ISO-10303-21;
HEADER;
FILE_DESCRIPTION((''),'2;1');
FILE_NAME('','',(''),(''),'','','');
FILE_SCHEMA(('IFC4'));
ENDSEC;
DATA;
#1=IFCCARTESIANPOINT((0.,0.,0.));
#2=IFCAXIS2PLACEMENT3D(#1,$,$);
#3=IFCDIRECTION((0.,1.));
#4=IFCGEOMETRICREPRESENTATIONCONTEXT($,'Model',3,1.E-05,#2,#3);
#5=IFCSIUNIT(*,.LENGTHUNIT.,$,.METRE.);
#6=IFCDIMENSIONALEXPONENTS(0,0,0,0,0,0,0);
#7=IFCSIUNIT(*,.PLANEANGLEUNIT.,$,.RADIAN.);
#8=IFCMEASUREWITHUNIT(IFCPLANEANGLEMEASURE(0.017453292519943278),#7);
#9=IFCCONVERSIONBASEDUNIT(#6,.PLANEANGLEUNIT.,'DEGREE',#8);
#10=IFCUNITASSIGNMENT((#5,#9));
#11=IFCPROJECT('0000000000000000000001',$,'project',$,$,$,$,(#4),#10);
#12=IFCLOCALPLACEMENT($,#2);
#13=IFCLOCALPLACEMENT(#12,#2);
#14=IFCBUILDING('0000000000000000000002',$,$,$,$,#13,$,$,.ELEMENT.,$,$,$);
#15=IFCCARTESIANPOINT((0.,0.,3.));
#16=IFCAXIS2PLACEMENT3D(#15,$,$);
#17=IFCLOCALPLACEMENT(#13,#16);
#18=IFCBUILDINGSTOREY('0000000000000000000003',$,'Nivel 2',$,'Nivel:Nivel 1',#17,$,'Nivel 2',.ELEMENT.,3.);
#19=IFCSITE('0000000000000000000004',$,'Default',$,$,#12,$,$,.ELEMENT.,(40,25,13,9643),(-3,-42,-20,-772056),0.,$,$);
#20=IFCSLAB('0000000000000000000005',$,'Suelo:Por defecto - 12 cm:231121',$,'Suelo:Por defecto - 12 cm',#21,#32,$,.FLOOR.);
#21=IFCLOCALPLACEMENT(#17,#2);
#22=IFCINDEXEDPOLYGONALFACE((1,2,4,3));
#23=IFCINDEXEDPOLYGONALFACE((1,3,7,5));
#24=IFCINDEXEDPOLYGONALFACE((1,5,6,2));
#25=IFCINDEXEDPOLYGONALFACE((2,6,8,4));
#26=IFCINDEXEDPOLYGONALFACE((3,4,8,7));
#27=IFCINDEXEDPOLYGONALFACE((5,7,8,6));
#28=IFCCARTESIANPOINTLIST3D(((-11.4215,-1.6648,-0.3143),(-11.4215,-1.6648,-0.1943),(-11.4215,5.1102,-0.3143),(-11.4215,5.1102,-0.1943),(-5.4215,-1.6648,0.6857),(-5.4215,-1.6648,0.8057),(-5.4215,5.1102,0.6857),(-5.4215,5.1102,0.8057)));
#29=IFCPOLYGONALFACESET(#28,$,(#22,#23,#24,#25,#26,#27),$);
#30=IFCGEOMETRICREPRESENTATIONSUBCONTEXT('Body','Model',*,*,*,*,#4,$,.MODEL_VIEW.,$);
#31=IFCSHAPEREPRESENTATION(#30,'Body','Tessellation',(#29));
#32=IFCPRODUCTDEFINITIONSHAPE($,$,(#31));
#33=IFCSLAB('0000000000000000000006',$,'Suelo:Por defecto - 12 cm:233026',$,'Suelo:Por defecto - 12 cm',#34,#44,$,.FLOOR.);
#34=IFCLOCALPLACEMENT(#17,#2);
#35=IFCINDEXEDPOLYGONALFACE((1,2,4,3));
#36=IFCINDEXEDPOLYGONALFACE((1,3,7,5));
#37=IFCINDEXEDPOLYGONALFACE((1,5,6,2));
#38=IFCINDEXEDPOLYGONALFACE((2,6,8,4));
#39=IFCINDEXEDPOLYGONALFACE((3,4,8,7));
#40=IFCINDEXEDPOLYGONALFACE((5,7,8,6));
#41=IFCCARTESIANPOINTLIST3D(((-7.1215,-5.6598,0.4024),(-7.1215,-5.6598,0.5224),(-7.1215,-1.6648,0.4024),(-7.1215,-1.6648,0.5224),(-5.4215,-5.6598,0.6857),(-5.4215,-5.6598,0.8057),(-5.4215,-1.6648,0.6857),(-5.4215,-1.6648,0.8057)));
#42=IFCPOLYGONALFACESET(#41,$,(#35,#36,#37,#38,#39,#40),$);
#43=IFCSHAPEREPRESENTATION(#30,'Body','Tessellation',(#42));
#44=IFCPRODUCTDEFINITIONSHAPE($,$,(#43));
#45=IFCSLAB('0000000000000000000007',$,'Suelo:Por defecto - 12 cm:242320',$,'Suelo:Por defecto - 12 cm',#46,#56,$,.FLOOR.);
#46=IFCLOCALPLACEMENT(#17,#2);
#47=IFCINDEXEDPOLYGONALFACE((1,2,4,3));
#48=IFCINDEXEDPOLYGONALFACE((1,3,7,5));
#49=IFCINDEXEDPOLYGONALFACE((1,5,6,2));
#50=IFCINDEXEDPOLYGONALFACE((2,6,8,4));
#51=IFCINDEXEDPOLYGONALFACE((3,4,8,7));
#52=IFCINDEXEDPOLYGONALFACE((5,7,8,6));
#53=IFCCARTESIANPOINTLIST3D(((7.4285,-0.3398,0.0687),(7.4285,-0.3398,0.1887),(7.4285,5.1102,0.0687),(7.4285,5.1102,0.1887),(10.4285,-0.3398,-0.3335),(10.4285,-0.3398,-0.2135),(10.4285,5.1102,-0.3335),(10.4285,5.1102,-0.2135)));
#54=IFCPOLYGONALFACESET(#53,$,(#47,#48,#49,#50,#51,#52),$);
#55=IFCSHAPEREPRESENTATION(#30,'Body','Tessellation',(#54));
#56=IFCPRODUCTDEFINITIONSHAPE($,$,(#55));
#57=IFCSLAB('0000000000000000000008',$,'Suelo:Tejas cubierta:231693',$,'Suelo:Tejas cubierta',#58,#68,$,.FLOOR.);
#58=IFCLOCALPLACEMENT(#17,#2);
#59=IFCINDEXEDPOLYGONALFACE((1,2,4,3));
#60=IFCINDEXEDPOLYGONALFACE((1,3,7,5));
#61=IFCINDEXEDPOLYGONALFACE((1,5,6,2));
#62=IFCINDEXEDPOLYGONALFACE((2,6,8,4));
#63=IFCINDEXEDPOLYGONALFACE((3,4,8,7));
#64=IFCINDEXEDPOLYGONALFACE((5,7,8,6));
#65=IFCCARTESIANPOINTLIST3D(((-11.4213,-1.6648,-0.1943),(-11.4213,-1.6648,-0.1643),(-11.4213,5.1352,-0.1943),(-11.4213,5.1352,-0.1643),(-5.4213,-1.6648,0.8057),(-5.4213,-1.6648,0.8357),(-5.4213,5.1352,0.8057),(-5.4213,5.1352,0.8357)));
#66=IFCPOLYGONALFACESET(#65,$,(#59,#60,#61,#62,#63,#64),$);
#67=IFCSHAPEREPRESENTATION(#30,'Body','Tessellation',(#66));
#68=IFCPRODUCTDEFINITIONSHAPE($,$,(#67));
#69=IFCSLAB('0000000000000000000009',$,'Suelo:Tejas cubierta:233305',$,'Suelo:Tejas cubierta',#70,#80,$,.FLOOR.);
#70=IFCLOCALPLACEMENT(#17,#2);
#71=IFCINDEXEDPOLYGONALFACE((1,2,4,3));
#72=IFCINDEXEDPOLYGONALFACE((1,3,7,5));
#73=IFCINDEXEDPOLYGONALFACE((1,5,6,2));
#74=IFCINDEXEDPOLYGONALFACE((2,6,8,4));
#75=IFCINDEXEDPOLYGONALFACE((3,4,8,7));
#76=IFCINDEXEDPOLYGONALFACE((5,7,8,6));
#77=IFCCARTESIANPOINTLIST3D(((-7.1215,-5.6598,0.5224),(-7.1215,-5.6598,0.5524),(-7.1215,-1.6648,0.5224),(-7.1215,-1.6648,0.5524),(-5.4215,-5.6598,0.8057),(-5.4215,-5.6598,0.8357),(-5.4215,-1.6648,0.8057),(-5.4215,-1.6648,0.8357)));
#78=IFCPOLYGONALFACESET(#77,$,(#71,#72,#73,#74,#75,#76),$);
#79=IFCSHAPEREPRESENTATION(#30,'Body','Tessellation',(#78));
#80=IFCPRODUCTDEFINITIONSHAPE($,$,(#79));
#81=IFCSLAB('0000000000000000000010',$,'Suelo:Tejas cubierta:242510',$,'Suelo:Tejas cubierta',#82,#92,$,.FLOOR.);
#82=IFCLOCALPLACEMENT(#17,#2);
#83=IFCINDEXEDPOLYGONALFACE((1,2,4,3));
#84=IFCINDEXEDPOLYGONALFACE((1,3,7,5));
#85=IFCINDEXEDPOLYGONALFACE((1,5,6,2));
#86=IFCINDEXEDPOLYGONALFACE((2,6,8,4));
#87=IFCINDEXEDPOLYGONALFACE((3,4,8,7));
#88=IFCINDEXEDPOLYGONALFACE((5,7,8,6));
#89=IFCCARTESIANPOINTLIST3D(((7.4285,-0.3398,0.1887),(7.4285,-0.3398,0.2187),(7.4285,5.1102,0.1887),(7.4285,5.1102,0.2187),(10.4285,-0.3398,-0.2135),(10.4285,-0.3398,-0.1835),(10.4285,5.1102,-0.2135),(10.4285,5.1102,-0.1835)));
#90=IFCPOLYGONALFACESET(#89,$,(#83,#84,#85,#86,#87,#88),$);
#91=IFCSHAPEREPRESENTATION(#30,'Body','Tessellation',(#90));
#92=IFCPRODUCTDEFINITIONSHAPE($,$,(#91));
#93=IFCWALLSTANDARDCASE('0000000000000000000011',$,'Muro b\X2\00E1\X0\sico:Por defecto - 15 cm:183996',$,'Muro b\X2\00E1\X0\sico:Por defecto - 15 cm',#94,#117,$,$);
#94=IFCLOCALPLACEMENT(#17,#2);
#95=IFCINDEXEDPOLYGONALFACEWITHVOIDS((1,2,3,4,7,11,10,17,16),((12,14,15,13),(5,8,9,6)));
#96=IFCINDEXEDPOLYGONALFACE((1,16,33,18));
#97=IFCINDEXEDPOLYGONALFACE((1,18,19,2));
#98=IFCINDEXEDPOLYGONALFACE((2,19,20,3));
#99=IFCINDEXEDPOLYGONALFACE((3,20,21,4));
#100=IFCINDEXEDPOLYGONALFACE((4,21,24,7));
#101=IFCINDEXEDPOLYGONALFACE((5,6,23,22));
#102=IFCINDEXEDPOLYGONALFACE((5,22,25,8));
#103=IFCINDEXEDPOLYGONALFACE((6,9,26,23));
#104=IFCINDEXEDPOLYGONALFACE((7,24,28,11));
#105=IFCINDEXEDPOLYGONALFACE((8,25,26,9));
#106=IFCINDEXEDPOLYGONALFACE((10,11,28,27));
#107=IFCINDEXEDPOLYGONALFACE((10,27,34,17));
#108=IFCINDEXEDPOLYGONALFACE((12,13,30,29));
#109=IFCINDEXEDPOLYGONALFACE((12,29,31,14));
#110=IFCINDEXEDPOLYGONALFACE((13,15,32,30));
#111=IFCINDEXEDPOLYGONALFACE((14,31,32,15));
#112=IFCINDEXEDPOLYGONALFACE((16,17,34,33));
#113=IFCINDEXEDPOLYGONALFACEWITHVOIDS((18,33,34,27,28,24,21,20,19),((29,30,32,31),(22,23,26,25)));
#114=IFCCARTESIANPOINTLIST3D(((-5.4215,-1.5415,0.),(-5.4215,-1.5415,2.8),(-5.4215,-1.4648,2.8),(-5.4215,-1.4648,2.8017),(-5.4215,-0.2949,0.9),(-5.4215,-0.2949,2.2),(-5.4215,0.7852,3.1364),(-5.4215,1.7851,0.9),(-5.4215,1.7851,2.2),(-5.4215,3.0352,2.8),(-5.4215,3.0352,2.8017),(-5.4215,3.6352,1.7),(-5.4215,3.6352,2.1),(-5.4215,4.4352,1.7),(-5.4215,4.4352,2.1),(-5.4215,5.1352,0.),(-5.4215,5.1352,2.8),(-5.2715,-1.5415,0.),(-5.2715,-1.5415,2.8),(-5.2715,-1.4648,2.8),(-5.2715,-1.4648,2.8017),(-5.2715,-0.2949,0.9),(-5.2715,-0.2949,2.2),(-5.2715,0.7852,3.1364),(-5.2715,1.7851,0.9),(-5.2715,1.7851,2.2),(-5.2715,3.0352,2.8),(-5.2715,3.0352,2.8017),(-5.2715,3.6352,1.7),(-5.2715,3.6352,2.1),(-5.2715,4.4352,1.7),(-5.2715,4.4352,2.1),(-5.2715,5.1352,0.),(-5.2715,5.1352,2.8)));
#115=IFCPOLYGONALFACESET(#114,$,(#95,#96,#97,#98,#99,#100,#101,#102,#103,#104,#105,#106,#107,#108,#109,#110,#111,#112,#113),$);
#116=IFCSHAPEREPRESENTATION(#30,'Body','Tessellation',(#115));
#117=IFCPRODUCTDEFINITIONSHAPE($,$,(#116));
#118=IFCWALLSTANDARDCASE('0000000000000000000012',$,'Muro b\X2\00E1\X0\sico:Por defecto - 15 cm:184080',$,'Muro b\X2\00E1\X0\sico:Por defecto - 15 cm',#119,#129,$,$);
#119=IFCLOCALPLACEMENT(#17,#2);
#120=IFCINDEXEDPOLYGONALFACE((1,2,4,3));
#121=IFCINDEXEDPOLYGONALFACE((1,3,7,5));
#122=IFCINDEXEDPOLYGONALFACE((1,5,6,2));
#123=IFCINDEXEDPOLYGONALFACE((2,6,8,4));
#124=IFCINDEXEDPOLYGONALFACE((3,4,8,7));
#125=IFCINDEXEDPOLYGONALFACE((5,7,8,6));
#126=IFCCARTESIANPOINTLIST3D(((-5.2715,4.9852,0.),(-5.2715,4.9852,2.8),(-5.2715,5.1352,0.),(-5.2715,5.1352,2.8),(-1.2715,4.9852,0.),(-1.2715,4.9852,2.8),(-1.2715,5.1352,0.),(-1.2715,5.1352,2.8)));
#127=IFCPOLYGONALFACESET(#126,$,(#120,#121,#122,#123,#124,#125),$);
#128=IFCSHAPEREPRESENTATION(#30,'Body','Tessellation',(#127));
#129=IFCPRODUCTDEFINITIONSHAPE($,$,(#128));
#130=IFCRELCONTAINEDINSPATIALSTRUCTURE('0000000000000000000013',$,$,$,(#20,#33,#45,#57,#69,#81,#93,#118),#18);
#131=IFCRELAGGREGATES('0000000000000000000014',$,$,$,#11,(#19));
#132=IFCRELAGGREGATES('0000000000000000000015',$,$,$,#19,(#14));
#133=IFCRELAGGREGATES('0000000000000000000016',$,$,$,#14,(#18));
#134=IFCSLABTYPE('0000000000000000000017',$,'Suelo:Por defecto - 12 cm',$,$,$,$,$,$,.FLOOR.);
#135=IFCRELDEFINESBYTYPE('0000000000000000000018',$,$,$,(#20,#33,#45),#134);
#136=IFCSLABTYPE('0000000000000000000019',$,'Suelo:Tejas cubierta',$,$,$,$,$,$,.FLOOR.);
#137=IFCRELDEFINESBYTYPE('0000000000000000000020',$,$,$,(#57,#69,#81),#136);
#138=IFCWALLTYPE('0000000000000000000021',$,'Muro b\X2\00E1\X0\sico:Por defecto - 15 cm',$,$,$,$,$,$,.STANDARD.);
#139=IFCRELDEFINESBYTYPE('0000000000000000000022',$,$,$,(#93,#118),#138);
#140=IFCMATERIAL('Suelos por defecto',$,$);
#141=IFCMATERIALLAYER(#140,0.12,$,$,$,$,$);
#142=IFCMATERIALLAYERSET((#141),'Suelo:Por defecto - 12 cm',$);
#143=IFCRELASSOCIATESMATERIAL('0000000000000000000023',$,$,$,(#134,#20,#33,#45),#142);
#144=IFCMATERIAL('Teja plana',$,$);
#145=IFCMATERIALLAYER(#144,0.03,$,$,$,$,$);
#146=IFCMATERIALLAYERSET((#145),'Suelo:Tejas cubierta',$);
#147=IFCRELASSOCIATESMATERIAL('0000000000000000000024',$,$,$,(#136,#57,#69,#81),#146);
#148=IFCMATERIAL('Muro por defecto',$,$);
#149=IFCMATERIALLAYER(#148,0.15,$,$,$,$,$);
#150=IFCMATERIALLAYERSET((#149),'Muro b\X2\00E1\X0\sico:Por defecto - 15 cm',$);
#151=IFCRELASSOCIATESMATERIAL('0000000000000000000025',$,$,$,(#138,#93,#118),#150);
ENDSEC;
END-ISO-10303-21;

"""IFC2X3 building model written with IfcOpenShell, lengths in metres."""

from ifc_helpers import new_model, entity, si_unit, converted_unit, direction, frame, frame_2d, origin, place, context, subcontext, project, spatial, polyline, rectangle, extrude, clip, halfspace, bounded_halfspace, material, layer, layer_set, layer_usage, type_object, element, save


model = new_model("IFC2X3")

# Units and contexts
model_context = context("Model", 3, precision=1e-05, world=origin(), true_north=direction((0.0, 1.0)))
body_context = subcontext(model_context, "Body", "Model", "MODEL_VIEW")
ifc_project = project(units=[si_unit("LENGTHUNIT", "METRE"), converted_unit("PLANEANGLEUNIT", "DEGREE", entity("IfcPlaneAngleMeasure", 0.017453292519943278), si_unit("PLANEANGLEUNIT", "RADIAN"), dimensions=[0, 0, 0, 0, 0, 0, 0])], contexts=[model_context])

# Site, building, storey
site_placement = place(None, origin())
site = spatial("IfcSite", under=ifc_project, at=site_placement, Name="Default", CompositionType="ELEMENT", RefLatitude=(40, 25, 13, 9643), RefLongitude=(-3, -42, -20, -772056), RefElevation=0.0)
building_placement = place(site_placement, origin())
building = spatial("IfcBuilding", under=site, at=building_placement, CompositionType="ELEMENT")
storey_placement = place(building_placement, frame((0.0, 0.0, 3.0)))
storey = spatial("IfcBuildingStorey", under=building, at=storey_placement, Name="Nivel 2", ObjectType="Nivel:Nivel 1", LongName="Nivel 2", CompositionType="ELEMENT", Elevation=3.0)

# Shared definitions
ifc_material_1 = material(Name="Suelos por defecto")

# Slabs
ifc_layer_1 = layer(ifc_material_1, 0.12)
ifc_layer_set_1 = layer_set([ifc_layer_1], Name="Suelo:Por defecto - 12 cm")
ifc_layer_usage_1 = layer_usage(ifc_layer_set_1, "AXIS3", "POSITIVE", 0.0)
slab_type_1 = type_object("IfcSlabType", Name="Suelo:Por defecto - 12 cm", PredefinedType="FLOOR", material=ifc_layer_set_1)
slab_1_placement = place(storey_placement, origin())
element("IfcSlab", 1, at=slab_1_placement, inside=storey, type_object=slab_type_1, material=ifc_layer_usage_1, Name="Suelo:Por defecto - 12 cm:231121", ObjectType="Suelo:Por defecto - 12 cm", PredefinedType="FLOOR", context=body_context, shape_type="SweptSolid", body=[
    clip(clip(extrude(rectangle(XDim=6.0828, YDim=6.775, at=frame_2d((0.0, 0.0), x_axis=(0.0, 1.0))), frame((-8.4215, 1.7227, 0.3057), z_axis=(0.164399, 0.0, -0.986394), x_axis=(0.0, 1.0, 0.0)), (0.0, -0.164399, 0.986394), 0.1217), halfspace(frame((-8.4215, 1.7227, 0.1857), z_axis=(0.164399, 0.0, -0.986394), x_axis=(0.986394, 0.0, 0.164399)), False)), halfspace(frame((-8.4215, 1.7227, 0.3057), z_axis=(-0.164399, 0.0, 0.986394), x_axis=(0.986394, 0.0, 0.164399)), False)),
])
ifc_layer_usage_2 = layer_usage(ifc_layer_set_1, "AXIS3", "POSITIVE", 0.0)
slab_2_placement = place(storey_placement, origin())
element("IfcSlab", 2, at=slab_2_placement, inside=storey, type_object=slab_type_1, material=ifc_layer_usage_2, Name="Suelo:Por defecto - 12 cm:233026", ObjectType="Suelo:Por defecto - 12 cm", PredefinedType="FLOOR", context=body_context, shape_type="SweptSolid", body=[
    clip(clip(extrude(rectangle(XDim=1.7234, YDim=3.995, at=frame_2d((0.0, 0.0), x_axis=(0.0, 1.0))), frame((-6.2715, -3.6623, 0.664), z_axis=(0.164399, 0.0, -0.986394), x_axis=(0.0, 1.0, 0.0)), (0.0, -0.164399, 0.986394), 0.1217), halfspace(frame((-6.2715, -3.6623, 0.544), z_axis=(0.164399, 0.0, -0.986394), x_axis=(-0.986394, 0.0, -0.164399)), False)), halfspace(frame((-6.2715, -3.6623, 0.664), z_axis=(-0.164399, 0.0, 0.986394), x_axis=(-0.986394, 0.0, -0.164399)), False)),
])
ifc_layer_usage_3 = layer_usage(ifc_layer_set_1, "AXIS3", "POSITIVE", 0.0)
slab_3_placement = place(storey_placement, origin())
element("IfcSlab", 3, at=slab_3_placement, inside=storey, type_object=slab_type_1, material=ifc_layer_usage_3, Name="Suelo:Por defecto - 12 cm:242320", ObjectType="Suelo:Por defecto - 12 cm", PredefinedType="FLOOR", context=body_context, shape_type="SweptSolid", body=[
    clip(clip(extrude(rectangle(XDim=3.0268, YDim=5.45, at=frame_2d((0.0, 0.0), x_axis=(0.0, 1.0))), frame((8.9285, 2.3852, -0.0124), z_axis=(-0.132875, 0.0, -0.991133), x_axis=(0.0, 1.0, 0.0)), (0.0, 0.132875, 0.991133), 0.1211), halfspace(frame((8.9285, 2.3852, -0.1324), z_axis=(-0.132875, 0.0, -0.991133), x_axis=(0.0, 1.0, 0.0)), False)), halfspace(frame((8.9285, 2.3852, -0.0124), z_axis=(0.132875, 0.0, 0.991133), x_axis=(0.0, 1.0, 0.0)), False)),
])
ifc_material_2 = material(Name="Teja plana")
ifc_layer_2 = layer(ifc_material_2, 0.03)
ifc_layer_set_2 = layer_set([ifc_layer_2], Name="Suelo:Tejas cubierta")
ifc_layer_usage_4 = layer_usage(ifc_layer_set_2, "AXIS3", "POSITIVE", 0.0)
slab_type_2 = type_object("IfcSlabType", Name="Suelo:Tejas cubierta", PredefinedType="FLOOR", material=ifc_layer_set_2)
slab_4_placement = place(storey_placement, origin())
element("IfcSlab", 4, at=slab_4_placement, inside=storey, type_object=slab_type_2, material=ifc_layer_usage_4, Name="Suelo:Tejas cubierta:231693", ObjectType="Suelo:Tejas cubierta", PredefinedType="FLOOR", context=body_context, shape_type="SweptSolid", body=[
    clip(clip(extrude(rectangle(XDim=6.0828, YDim=6.8, at=frame_2d((0.0, 0.0), x_axis=(0.0, 1.0))), frame((-8.4213, 1.7352, 0.3357), z_axis=(0.164399, 0.0, -0.986394), x_axis=(0.0, 1.0, 0.0)), (0.0, -0.164399, 0.986394), 0.0304), halfspace(frame((-8.4213, 1.7352, 0.3057), z_axis=(0.164399, 0.0, -0.986394), x_axis=(0.986394, 0.0, 0.164399)), False)), halfspace(frame((-8.4213, 1.7352, 0.3357), z_axis=(-0.164399, 0.0, 0.986394), x_axis=(0.986394, 0.0, 0.164399)), False)),
])
ifc_layer_usage_5 = layer_usage(ifc_layer_set_2, "AXIS3", "POSITIVE", 0.0)
slab_5_placement = place(storey_placement, origin())
element("IfcSlab", 5, at=slab_5_placement, inside=storey, type_object=slab_type_2, material=ifc_layer_usage_5, Name="Suelo:Tejas cubierta:233305", ObjectType="Suelo:Tejas cubierta", PredefinedType="FLOOR", context=body_context, shape_type="SweptSolid", body=[
    clip(clip(extrude(rectangle(XDim=1.7234, YDim=3.995, at=frame_2d((0.0, 0.0), x_axis=(0.0, 1.0))), frame((-6.2715, -3.6623, 0.694), z_axis=(0.164399, 0.0, -0.986394), x_axis=(0.0, 1.0, 0.0)), (0.0, -0.164399, 0.986394), 0.0304), halfspace(frame((-6.2715, -3.6623, 0.664), z_axis=(0.164399, 0.0, -0.986394), x_axis=(-0.986394, 0.0, -0.164399)), False)), halfspace(frame((-6.2715, -3.6623, 0.694), z_axis=(-0.164399, 0.0, 0.986394), x_axis=(-0.986394, 0.0, -0.164399)), False)),
])
ifc_layer_usage_6 = layer_usage(ifc_layer_set_2, "AXIS3", "POSITIVE", 0.0)
slab_6_placement = place(storey_placement, origin())
element("IfcSlab", 6, at=slab_6_placement, inside=storey, type_object=slab_type_2, material=ifc_layer_usage_6, Name="Suelo:Tejas cubierta:242510", ObjectType="Suelo:Tejas cubierta", PredefinedType="FLOOR", context=body_context, shape_type="SweptSolid", body=[
    clip(clip(extrude(rectangle(XDim=3.0268, YDim=5.45, at=frame_2d((0.0, 0.0), x_axis=(0.0, 1.0))), frame((8.9285, 2.3852, 0.0176), z_axis=(-0.132875, 0.0, -0.991133), x_axis=(0.0, 1.0, 0.0)), (0.0, 0.132875, 0.991133), 0.0303), halfspace(frame((8.9285, 2.3852, -0.0124), z_axis=(-0.132875, 0.0, -0.991133), x_axis=(0.0, 1.0, 0.0)), False)), halfspace(frame((8.9285, 2.3852, 0.0176), z_axis=(0.132875, 0.0, 0.991133), x_axis=(0.0, 1.0, 0.0)), False)),
])

# Wall, openings
ifc_material_3 = material(Name="Muro por defecto")
ifc_layer_3 = layer(ifc_material_3, 0.15)
ifc_layer_set_3 = layer_set([ifc_layer_3], Name="Muro básico:Por defecto - 15 cm")
ifc_layer_usage_7 = layer_usage(ifc_layer_set_3, "AXIS2", "NEGATIVE", 0.075)
wall_type = type_object("IfcWallType", Name="Muro básico:Por defecto - 15 cm", PredefinedType="STANDARD", material=ifc_layer_set_3)
wall_1_placement = place(storey_placement, frame((-5.3465, -1.5415, 0.0), z_axis=(0.0, 0.0, 1.0), x_axis=(0.0, 1.0, 0.0)))
wall_1 = element("IfcWallStandardCase", 7, at=wall_1_placement, inside=storey, type_object=wall_type, material=ifc_layer_usage_7, Name="Muro básico:Por defecto - 15 cm:183996", ObjectType="Muro básico:Por defecto - 15 cm", context=body_context, shape_type="Clipping", body=[
    clip(clip(clip(clip(clip(extrude(rectangle(XDim=6.6768, YDim=0.15, at=frame_2d((3.3384, 0.0), x_axis=(-1.0, 0.0))), origin(), (0.0, 0.0, 1.0), 3.1364), bounded_halfspace(frame((4.5768, -0.075, 2.8), z_axis=(0.0, 0.0, -1.0), x_axis=(0.0, -1.0, 0.0)), True, frame((4.5768, -0.075, 2.8)), polyline([(0.0, 0.0), (0.075, 0.0), (1.95, 0.0), (2.1, 0.0), (2.1, 0.15), (0.0, 0.15), (0.0, 0.0)]))), bounded_halfspace(frame((2.3268, -0.075, 3.1364), z_axis=(0.147125, 0.0, 0.989118), x_axis=(0.0, 1.0, 0.0)), False, frame((2.3268, -0.075, 3.1364)), polyline([(0.0, 0.0), (2.25, 0.0), (2.25, 0.15), (0.0, 0.15), (0.0, 0.0)]))), bounded_halfspace(frame((0.0768, -0.075, 2.8017), z_axis=(-0.147131, 0.0, 0.989117), x_axis=(0.0, -1.0, 0.0)), False, frame((0.0768, -0.075, 2.8017)), polyline([(0.0, 0.0), (2.25, 0.0), (2.25, 0.15), (0.0, 0.15), (0.0, 0.0)]))), bounded_halfspace(frame((4.5768, -0.075, 2.8), z_axis=(0.0, 0.0, -1.0), x_axis=(0.0, -1.0, 0.0)), True, frame((4.5768, -0.075, 2.8)), polyline([(0.0, 0.0), (0.075, 0.0), (1.95, 0.0), (2.1, 0.0), (2.1, 0.15), (0.0, 0.15), (0.0, 0.0)]))), bounded_halfspace(frame((0.0, -0.075, 2.8), z_axis=(0.0, 0.0, 1.0), x_axis=(0.0, 1.0, 0.0)), False, frame((0.0, -0.075, 2.8)), polyline([(0.0, 0.0), (0.0768, 0.0), (0.0768, 0.15), (0.0, 0.15), (0.0, 0.0)]))),
])
opening_1_placement = place(wall_1_placement, frame((5.1768, -0.075, 1.7)))
element("IfcOpeningElement", 8, at=opening_1_placement, cuts=wall_1, ObjectType="Opening", context=body_context, shape_type="SweptSolid", body=[
    extrude(rectangle(XDim=0.4, YDim=0.8, at=frame_2d((0.2, 0.4), x_axis=(1.0, 0.0))), frame((0.0, 0.0, 0.0), z_axis=(0.0, 1.0, 0.0), x_axis=(0.0, 0.0, 1.0)), (0.0, 0.0, 1.0), 0.15),
])
opening_2_placement = place(wall_1_placement, frame((1.2466, -0.075, 0.9)))
element("IfcOpeningElement", 9, at=opening_2_placement, cuts=wall_1, ObjectType="Opening", context=body_context, shape_type="SweptSolid", body=[
    extrude(rectangle(XDim=1.3, YDim=2.08, at=frame_2d((0.65, 1.04), x_axis=(-1.0, 0.0))), frame((0.0, 0.0, 0.0), z_axis=(0.0, 1.0, 0.0), x_axis=(0.0, 0.0, 1.0)), (0.0, 0.0, 1.0), 0.15),
])

# Wall
ifc_layer_usage_8 = layer_usage(ifc_layer_set_3, "AXIS2", "NEGATIVE", 0.075)
wall_2_placement = place(storey_placement, frame((-5.2715, 5.0602, 0.0)))
element("IfcWallStandardCase", 10, at=wall_2_placement, inside=storey, type_object=wall_type, material=ifc_layer_usage_8, Name="Muro básico:Por defecto - 15 cm:184080", ObjectType="Muro básico:Por defecto - 15 cm", context=body_context, shape_type="Clipping", body=[
    clip(extrude(rectangle(XDim=4.0, YDim=0.15, at=frame_2d((2.0, 0.0), x_axis=(-1.0, 0.0))), origin(), (0.0, 0.0, 1.0), 2.8), bounded_halfspace(frame((0.0, -0.075, 2.8), z_axis=(0.0, 0.0, -1.0), x_axis=(1.0, 0.0, 0.0)), True, frame((0.0, -0.075, 2.8)), polyline([(0.0, 0.0), (1.85, 0.0), (2.0, 0.0), (3.85, 0.0), (4.0, 0.0), (4.0, 0.15), (0.0, 0.15), (0.0, 0.0)]))),
])

save(model, "model.ifc")
